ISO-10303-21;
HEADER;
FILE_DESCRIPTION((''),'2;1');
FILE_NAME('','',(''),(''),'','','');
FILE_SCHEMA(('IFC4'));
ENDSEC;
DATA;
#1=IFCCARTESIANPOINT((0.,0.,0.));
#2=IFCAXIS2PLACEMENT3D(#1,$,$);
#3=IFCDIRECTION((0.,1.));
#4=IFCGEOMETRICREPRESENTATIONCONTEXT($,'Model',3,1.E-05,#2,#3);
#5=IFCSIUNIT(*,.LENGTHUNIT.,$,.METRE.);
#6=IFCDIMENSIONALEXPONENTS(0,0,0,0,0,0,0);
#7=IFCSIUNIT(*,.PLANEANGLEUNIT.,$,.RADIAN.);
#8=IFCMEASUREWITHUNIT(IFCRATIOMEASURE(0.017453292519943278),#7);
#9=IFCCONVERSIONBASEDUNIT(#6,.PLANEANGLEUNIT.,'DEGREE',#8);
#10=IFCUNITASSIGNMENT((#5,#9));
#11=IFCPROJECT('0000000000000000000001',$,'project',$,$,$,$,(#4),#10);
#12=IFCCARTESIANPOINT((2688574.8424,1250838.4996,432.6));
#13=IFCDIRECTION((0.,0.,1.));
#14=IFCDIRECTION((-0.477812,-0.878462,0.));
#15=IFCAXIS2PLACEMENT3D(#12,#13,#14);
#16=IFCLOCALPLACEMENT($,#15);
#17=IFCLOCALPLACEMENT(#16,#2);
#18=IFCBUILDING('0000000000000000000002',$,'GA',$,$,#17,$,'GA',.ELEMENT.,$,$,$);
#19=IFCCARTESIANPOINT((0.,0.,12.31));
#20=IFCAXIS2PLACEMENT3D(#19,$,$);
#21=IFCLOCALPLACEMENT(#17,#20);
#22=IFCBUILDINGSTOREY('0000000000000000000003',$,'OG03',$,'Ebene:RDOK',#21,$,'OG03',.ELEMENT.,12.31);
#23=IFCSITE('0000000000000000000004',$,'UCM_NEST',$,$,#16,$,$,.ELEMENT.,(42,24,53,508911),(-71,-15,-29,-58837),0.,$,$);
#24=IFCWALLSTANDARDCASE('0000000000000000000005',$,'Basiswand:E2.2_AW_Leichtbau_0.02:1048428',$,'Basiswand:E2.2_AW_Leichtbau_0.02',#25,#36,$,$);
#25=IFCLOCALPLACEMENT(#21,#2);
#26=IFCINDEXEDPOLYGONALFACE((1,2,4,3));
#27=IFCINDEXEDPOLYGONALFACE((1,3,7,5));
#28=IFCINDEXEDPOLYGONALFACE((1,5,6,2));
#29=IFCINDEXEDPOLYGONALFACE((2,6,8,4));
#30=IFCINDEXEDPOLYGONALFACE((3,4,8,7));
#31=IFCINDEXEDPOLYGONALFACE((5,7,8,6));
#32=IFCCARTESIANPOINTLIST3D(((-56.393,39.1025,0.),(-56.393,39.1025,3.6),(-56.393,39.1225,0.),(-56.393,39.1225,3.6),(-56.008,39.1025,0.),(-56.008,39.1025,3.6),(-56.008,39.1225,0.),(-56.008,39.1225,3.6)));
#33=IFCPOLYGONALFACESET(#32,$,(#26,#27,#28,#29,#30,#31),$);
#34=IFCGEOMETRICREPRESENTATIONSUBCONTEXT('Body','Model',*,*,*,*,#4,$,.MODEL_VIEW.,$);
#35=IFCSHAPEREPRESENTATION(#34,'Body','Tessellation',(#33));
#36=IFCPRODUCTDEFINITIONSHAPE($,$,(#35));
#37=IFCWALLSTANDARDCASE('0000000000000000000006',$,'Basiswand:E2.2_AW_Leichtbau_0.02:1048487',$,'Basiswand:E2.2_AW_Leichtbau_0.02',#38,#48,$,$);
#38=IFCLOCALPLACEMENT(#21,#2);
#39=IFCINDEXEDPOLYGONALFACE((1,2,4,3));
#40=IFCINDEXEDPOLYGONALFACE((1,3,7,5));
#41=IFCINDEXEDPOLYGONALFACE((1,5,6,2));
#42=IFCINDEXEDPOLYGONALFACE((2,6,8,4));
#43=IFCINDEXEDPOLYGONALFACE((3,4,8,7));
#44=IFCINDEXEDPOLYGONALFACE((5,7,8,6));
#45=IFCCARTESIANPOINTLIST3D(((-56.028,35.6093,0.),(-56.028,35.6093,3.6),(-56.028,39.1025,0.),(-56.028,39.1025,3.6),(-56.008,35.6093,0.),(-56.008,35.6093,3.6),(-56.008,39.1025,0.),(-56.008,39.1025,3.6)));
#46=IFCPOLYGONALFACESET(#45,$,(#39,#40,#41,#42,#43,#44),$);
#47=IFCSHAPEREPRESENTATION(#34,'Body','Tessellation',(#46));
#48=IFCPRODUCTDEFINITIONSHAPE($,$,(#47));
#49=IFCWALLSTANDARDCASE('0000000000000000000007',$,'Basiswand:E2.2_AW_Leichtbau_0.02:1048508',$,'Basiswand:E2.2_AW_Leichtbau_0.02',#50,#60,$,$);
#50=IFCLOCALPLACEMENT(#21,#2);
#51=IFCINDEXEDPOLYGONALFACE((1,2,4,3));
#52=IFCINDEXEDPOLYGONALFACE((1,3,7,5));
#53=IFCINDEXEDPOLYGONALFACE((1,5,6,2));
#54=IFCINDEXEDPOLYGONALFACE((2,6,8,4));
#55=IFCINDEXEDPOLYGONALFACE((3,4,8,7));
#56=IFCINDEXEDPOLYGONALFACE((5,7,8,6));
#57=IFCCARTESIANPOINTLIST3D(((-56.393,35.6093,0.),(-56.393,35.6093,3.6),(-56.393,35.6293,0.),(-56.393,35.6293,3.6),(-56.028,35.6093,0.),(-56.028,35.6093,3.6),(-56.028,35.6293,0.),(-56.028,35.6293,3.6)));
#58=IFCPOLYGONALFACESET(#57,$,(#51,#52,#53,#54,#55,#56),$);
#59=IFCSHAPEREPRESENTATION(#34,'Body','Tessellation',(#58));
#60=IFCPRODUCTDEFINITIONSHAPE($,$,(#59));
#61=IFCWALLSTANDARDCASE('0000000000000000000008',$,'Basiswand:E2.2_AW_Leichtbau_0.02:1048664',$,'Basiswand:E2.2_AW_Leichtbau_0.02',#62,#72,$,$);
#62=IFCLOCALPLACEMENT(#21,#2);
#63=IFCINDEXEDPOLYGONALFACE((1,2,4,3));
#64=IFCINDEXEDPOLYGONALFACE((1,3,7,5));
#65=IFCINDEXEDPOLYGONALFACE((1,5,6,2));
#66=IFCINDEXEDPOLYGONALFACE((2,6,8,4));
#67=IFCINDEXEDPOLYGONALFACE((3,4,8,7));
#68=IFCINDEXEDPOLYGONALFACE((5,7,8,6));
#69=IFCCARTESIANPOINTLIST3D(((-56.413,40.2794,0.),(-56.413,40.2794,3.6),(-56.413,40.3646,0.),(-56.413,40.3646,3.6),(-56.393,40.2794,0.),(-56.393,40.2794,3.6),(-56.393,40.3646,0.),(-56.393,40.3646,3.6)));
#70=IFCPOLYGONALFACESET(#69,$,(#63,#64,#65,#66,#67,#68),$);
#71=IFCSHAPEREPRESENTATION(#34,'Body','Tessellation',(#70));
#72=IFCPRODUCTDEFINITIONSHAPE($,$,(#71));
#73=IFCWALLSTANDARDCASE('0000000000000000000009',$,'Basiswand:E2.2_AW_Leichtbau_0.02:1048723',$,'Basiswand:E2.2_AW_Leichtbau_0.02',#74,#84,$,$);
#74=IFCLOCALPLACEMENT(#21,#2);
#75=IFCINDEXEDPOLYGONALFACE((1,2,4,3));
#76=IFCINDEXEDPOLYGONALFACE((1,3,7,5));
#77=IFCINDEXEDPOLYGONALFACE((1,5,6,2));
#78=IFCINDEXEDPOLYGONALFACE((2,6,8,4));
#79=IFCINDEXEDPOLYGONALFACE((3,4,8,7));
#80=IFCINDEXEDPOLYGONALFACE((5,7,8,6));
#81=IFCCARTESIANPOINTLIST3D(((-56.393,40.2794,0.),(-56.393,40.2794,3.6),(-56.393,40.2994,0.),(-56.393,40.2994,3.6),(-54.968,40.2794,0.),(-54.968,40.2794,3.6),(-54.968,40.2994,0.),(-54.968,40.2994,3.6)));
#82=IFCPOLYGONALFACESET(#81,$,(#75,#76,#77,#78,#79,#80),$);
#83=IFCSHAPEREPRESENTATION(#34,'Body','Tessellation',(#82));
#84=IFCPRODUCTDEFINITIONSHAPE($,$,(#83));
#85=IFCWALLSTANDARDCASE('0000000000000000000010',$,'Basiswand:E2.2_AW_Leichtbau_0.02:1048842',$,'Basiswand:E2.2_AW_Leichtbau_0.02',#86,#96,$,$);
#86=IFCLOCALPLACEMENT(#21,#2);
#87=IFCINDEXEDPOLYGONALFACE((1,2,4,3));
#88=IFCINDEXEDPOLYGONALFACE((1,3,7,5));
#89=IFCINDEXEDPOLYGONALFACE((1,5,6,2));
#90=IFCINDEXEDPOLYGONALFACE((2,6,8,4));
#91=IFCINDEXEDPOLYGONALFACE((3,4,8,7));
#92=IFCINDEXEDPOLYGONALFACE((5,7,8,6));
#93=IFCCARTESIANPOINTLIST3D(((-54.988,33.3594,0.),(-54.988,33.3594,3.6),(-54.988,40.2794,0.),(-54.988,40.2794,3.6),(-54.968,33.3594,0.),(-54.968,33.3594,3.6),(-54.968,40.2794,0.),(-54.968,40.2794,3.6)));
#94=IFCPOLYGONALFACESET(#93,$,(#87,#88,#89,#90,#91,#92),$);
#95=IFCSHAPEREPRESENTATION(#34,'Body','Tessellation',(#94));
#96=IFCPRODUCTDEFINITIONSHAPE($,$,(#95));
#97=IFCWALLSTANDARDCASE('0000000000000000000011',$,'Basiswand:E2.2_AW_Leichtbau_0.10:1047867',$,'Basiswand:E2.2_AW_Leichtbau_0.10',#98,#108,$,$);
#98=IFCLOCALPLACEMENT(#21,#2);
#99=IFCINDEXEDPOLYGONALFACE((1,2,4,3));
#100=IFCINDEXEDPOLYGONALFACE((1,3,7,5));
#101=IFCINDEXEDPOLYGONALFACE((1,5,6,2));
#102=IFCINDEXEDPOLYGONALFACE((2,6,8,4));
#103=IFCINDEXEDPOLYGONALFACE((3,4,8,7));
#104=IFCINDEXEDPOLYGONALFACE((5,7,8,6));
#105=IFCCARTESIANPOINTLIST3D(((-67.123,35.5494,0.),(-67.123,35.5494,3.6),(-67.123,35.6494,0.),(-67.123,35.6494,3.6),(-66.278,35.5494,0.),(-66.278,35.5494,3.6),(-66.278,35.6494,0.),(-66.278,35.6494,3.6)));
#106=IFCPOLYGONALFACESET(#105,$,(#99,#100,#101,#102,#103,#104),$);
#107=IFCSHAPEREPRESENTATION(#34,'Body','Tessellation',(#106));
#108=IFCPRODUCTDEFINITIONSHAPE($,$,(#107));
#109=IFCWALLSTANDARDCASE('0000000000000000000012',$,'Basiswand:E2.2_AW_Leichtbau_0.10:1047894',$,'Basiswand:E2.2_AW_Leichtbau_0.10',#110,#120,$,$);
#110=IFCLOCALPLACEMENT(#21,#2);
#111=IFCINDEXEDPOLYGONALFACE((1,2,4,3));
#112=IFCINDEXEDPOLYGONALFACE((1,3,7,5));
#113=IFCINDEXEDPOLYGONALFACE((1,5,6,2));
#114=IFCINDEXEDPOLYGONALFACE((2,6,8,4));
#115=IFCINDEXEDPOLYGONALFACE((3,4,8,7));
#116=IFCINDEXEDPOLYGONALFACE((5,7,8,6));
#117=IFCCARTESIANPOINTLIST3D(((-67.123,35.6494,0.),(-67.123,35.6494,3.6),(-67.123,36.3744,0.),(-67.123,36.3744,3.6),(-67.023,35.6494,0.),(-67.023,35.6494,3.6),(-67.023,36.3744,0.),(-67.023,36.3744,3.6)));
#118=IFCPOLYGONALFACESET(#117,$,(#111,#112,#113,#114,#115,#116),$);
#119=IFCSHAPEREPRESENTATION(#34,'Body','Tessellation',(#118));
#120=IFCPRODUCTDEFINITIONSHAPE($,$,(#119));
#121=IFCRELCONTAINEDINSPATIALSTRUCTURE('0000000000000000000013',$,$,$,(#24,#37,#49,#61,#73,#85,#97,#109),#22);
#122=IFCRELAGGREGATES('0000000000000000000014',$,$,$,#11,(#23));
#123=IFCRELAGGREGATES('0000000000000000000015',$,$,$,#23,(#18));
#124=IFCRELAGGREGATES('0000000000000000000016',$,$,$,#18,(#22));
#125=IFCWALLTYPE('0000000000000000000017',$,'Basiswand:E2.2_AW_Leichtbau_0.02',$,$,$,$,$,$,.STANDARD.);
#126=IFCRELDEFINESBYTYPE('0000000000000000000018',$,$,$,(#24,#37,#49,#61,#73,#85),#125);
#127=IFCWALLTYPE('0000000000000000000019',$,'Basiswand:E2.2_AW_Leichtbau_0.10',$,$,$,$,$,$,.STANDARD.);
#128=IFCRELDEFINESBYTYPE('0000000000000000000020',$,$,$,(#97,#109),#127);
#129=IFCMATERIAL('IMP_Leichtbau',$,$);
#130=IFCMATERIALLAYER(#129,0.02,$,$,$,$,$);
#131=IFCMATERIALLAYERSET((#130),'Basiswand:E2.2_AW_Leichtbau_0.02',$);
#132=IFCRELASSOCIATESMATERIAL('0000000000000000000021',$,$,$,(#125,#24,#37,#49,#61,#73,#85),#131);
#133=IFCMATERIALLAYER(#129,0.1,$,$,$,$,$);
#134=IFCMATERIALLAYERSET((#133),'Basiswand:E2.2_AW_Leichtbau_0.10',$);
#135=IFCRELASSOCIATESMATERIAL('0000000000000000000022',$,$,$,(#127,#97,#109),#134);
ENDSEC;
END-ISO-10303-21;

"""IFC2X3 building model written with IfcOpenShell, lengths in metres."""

from ifc_helpers import new_model, entity, si_unit, converted_unit, direction, frame, frame_2d, origin, place, context, subcontext, project, spatial, rectangle, extrude, material, layer, layer_set, layer_usage, type_object, element, save


model = new_model("IFC2X3")

# Units and contexts
model_context = context("Model", 3, precision=1e-05, world=origin(), true_north=direction((0.0, 1.0)))
body_context = subcontext(model_context, "Body", "Model", "MODEL_VIEW")
ifc_project = project(units=[si_unit("LENGTHUNIT", "METRE"), converted_unit("PLANEANGLEUNIT", "DEGREE", entity("IfcRatioMeasure", 0.017453292519943278), si_unit("PLANEANGLEUNIT", "RADIAN"), dimensions=[0, 0, 0, 0, 0, 0, 0])], contexts=[model_context])

# Site, building, storey
site_placement = place(None, frame((2688574.8424, 1250838.4996, 432.6), z_axis=(0.0, 0.0, 1.0), x_axis=(-0.477812, -0.878462, 0.0)))
site = spatial("IfcSite", under=ifc_project, at=site_placement, Name="UCM_NEST", CompositionType="ELEMENT", RefLatitude=(42, 24, 53, 508911), RefLongitude=(-71, -15, -29, -58837), RefElevation=0.0)
building_placement = place(site_placement, origin())
building = spatial("IfcBuilding", under=site, at=building_placement, Name="GA", LongName="GA", CompositionType="ELEMENT")
storey_placement = place(building_placement, frame((0.0, 0.0, 12.31)))
storey = spatial("IfcBuildingStorey", under=building, at=storey_placement, Name="OG03", ObjectType="Ebene:RDOK", LongName="OG03", CompositionType="ELEMENT", Elevation=12.31)

# Walls
ifc_material_1 = material(Name="IMP_Leichtbau")
ifc_layer_1 = layer(ifc_material_1, 0.02)
ifc_layer_set_1 = layer_set([ifc_layer_1], Name="Basiswand:E2.2_AW_Leichtbau_0.02")
ifc_layer_usage_1 = layer_usage(ifc_layer_set_1, "AXIS2", "NEGATIVE", 0.01)
wall_type_1 = type_object("IfcWallType", Name="Basiswand:E2.2_AW_Leichtbau_0.02", PredefinedType="STANDARD", material=ifc_layer_set_1)
wall_1_placement = place(storey_placement, frame((-56.393, 39.1125, 0.0)))
element("IfcWallStandardCase", 1, at=wall_1_placement, inside=storey, type_object=wall_type_1, material=ifc_layer_usage_1, Name="Basiswand:E2.2_AW_Leichtbau_0.02:1048428", ObjectType="Basiswand:E2.2_AW_Leichtbau_0.02", context=body_context, shape_type="SweptSolid", body=[
    extrude(rectangle(XDim=0.385, YDim=0.02, at=frame_2d((0.1925, 0.0), x_axis=(-1.0, 0.0))), origin(), (0.0, 0.0, 1.0), 3.6),
])
wall_2_placement = place(storey_placement, frame((-56.018, 39.1025, 0.0), z_axis=(0.0, 0.0, 1.0), x_axis=(0.0, -1.0, 0.0)))
element("IfcWallStandardCase", 2, at=wall_2_placement, inside=storey, type_object=wall_type_1, material=ifc_layer_usage_1, Name="Basiswand:E2.2_AW_Leichtbau_0.02:1048487", ObjectType="Basiswand:E2.2_AW_Leichtbau_0.02", context=body_context, shape_type="SweptSolid", body=[
    extrude(rectangle(XDim=3.4932, YDim=0.02, at=frame_2d((1.7466, 0.0), x_axis=(-1.0, 0.0))), origin(), (0.0, 0.0, 1.0), 3.6),
])
wall_3_placement = place(storey_placement, frame((-56.028, 35.6193, 0.0), z_axis=(0.0, 0.0, 1.0), x_axis=(-1.0, 0.0, 0.0)))
element("IfcWallStandardCase", 3, at=wall_3_placement, inside=storey, type_object=wall_type_1, material=ifc_layer_usage_1, Name="Basiswand:E2.2_AW_Leichtbau_0.02:1048508", ObjectType="Basiswand:E2.2_AW_Leichtbau_0.02", context=body_context, shape_type="SweptSolid", body=[
    extrude(rectangle(XDim=0.365, YDim=0.02, at=frame_2d((0.1825, 0.0), x_axis=(-1.0, 0.0))), origin(), (0.0, 0.0, 1.0), 3.6),
])
wall_4_placement = place(storey_placement, frame((-56.403, 40.3646, 0.0), z_axis=(0.0, 0.0, 1.0), x_axis=(0.0, -1.0, 0.0)))
element("IfcWallStandardCase", 4, at=wall_4_placement, inside=storey, type_object=wall_type_1, material=ifc_layer_usage_1, Name="Basiswand:E2.2_AW_Leichtbau_0.02:1048664", ObjectType="Basiswand:E2.2_AW_Leichtbau_0.02", context=body_context, shape_type="SweptSolid", body=[
    extrude(rectangle(XDim=0.0852, YDim=0.02, at=frame_2d((0.0426, 0.0), x_axis=(-1.0, 0.0))), origin(), (0.0, 0.0, 1.0), 3.6),
])
wall_5_placement = place(storey_placement, frame((-56.393, 40.2894, 0.0)))
element("IfcWallStandardCase", 5, at=wall_5_placement, inside=storey, type_object=wall_type_1, material=ifc_layer_usage_1, Name="Basiswand:E2.2_AW_Leichtbau_0.02:1048723", ObjectType="Basiswand:E2.2_AW_Leichtbau_0.02", context=body_context, shape_type="SweptSolid", body=[
    extrude(rectangle(XDim=1.425, YDim=0.02, at=frame_2d((0.7125, 0.0), x_axis=(-1.0, 0.0))), origin(), (0.0, 0.0, 1.0), 3.6),
])
wall_6_placement = place(storey_placement, frame((-54.978, 40.2794, 0.0), z_axis=(0.0, 0.0, 1.0), x_axis=(0.0, -1.0, 0.0)))
element("IfcWallStandardCase", 6, at=wall_6_placement, inside=storey, type_object=wall_type_1, material=ifc_layer_usage_1, Name="Basiswand:E2.2_AW_Leichtbau_0.02:1048842", ObjectType="Basiswand:E2.2_AW_Leichtbau_0.02", context=body_context, shape_type="SweptSolid", body=[
    extrude(rectangle(XDim=6.92, YDim=0.02, at=frame_2d((3.46, 0.0), x_axis=(-1.0, 0.0))), origin(), (0.0, 0.0, 1.0), 3.6),
])
ifc_layer_2 = layer(ifc_material_1, 0.1)
ifc_layer_set_2 = layer_set([ifc_layer_2], Name="Basiswand:E2.2_AW_Leichtbau_0.10")
ifc_layer_usage_2 = layer_usage(ifc_layer_set_2, "AXIS2", "NEGATIVE", 0.05)
wall_type_2 = type_object("IfcWallType", Name="Basiswand:E2.2_AW_Leichtbau_0.10", PredefinedType="STANDARD", material=ifc_layer_set_2)
wall_7_placement = place(storey_placement, frame((-66.278, 35.5994, 0.0), z_axis=(0.0, 0.0, 1.0), x_axis=(-1.0, 0.0, 0.0)))
element("IfcWallStandardCase", 7, at=wall_7_placement, inside=storey, type_object=wall_type_2, material=ifc_layer_usage_2, Name="Basiswand:E2.2_AW_Leichtbau_0.10:1047867", ObjectType="Basiswand:E2.2_AW_Leichtbau_0.10", context=body_context, shape_type="SweptSolid", body=[
    extrude(rectangle(XDim=0.845, YDim=0.1, at=frame_2d((0.4225, 0.0), x_axis=(-1.0, 0.0))), origin(), (0.0, 0.0, 1.0), 3.6),
])
wall_8_placement = place(storey_placement, frame((-67.073, 35.6494, 0.0), z_axis=(0.0, 0.0, 1.0), x_axis=(0.0, 1.0, 0.0)))
element("IfcWallStandardCase", 8, at=wall_8_placement, inside=storey, type_object=wall_type_2, material=ifc_layer_usage_2, Name="Basiswand:E2.2_AW_Leichtbau_0.10:1047894", ObjectType="Basiswand:E2.2_AW_Leichtbau_0.10", context=body_context, shape_type="SweptSolid", body=[
    extrude(rectangle(XDim=0.725, YDim=0.1, at=frame_2d((0.3625, 0.0), x_axis=(-1.0, 0.0))), origin(), (0.0, 0.0, 1.0), 3.6),
])

save(model, "model.ifc")
